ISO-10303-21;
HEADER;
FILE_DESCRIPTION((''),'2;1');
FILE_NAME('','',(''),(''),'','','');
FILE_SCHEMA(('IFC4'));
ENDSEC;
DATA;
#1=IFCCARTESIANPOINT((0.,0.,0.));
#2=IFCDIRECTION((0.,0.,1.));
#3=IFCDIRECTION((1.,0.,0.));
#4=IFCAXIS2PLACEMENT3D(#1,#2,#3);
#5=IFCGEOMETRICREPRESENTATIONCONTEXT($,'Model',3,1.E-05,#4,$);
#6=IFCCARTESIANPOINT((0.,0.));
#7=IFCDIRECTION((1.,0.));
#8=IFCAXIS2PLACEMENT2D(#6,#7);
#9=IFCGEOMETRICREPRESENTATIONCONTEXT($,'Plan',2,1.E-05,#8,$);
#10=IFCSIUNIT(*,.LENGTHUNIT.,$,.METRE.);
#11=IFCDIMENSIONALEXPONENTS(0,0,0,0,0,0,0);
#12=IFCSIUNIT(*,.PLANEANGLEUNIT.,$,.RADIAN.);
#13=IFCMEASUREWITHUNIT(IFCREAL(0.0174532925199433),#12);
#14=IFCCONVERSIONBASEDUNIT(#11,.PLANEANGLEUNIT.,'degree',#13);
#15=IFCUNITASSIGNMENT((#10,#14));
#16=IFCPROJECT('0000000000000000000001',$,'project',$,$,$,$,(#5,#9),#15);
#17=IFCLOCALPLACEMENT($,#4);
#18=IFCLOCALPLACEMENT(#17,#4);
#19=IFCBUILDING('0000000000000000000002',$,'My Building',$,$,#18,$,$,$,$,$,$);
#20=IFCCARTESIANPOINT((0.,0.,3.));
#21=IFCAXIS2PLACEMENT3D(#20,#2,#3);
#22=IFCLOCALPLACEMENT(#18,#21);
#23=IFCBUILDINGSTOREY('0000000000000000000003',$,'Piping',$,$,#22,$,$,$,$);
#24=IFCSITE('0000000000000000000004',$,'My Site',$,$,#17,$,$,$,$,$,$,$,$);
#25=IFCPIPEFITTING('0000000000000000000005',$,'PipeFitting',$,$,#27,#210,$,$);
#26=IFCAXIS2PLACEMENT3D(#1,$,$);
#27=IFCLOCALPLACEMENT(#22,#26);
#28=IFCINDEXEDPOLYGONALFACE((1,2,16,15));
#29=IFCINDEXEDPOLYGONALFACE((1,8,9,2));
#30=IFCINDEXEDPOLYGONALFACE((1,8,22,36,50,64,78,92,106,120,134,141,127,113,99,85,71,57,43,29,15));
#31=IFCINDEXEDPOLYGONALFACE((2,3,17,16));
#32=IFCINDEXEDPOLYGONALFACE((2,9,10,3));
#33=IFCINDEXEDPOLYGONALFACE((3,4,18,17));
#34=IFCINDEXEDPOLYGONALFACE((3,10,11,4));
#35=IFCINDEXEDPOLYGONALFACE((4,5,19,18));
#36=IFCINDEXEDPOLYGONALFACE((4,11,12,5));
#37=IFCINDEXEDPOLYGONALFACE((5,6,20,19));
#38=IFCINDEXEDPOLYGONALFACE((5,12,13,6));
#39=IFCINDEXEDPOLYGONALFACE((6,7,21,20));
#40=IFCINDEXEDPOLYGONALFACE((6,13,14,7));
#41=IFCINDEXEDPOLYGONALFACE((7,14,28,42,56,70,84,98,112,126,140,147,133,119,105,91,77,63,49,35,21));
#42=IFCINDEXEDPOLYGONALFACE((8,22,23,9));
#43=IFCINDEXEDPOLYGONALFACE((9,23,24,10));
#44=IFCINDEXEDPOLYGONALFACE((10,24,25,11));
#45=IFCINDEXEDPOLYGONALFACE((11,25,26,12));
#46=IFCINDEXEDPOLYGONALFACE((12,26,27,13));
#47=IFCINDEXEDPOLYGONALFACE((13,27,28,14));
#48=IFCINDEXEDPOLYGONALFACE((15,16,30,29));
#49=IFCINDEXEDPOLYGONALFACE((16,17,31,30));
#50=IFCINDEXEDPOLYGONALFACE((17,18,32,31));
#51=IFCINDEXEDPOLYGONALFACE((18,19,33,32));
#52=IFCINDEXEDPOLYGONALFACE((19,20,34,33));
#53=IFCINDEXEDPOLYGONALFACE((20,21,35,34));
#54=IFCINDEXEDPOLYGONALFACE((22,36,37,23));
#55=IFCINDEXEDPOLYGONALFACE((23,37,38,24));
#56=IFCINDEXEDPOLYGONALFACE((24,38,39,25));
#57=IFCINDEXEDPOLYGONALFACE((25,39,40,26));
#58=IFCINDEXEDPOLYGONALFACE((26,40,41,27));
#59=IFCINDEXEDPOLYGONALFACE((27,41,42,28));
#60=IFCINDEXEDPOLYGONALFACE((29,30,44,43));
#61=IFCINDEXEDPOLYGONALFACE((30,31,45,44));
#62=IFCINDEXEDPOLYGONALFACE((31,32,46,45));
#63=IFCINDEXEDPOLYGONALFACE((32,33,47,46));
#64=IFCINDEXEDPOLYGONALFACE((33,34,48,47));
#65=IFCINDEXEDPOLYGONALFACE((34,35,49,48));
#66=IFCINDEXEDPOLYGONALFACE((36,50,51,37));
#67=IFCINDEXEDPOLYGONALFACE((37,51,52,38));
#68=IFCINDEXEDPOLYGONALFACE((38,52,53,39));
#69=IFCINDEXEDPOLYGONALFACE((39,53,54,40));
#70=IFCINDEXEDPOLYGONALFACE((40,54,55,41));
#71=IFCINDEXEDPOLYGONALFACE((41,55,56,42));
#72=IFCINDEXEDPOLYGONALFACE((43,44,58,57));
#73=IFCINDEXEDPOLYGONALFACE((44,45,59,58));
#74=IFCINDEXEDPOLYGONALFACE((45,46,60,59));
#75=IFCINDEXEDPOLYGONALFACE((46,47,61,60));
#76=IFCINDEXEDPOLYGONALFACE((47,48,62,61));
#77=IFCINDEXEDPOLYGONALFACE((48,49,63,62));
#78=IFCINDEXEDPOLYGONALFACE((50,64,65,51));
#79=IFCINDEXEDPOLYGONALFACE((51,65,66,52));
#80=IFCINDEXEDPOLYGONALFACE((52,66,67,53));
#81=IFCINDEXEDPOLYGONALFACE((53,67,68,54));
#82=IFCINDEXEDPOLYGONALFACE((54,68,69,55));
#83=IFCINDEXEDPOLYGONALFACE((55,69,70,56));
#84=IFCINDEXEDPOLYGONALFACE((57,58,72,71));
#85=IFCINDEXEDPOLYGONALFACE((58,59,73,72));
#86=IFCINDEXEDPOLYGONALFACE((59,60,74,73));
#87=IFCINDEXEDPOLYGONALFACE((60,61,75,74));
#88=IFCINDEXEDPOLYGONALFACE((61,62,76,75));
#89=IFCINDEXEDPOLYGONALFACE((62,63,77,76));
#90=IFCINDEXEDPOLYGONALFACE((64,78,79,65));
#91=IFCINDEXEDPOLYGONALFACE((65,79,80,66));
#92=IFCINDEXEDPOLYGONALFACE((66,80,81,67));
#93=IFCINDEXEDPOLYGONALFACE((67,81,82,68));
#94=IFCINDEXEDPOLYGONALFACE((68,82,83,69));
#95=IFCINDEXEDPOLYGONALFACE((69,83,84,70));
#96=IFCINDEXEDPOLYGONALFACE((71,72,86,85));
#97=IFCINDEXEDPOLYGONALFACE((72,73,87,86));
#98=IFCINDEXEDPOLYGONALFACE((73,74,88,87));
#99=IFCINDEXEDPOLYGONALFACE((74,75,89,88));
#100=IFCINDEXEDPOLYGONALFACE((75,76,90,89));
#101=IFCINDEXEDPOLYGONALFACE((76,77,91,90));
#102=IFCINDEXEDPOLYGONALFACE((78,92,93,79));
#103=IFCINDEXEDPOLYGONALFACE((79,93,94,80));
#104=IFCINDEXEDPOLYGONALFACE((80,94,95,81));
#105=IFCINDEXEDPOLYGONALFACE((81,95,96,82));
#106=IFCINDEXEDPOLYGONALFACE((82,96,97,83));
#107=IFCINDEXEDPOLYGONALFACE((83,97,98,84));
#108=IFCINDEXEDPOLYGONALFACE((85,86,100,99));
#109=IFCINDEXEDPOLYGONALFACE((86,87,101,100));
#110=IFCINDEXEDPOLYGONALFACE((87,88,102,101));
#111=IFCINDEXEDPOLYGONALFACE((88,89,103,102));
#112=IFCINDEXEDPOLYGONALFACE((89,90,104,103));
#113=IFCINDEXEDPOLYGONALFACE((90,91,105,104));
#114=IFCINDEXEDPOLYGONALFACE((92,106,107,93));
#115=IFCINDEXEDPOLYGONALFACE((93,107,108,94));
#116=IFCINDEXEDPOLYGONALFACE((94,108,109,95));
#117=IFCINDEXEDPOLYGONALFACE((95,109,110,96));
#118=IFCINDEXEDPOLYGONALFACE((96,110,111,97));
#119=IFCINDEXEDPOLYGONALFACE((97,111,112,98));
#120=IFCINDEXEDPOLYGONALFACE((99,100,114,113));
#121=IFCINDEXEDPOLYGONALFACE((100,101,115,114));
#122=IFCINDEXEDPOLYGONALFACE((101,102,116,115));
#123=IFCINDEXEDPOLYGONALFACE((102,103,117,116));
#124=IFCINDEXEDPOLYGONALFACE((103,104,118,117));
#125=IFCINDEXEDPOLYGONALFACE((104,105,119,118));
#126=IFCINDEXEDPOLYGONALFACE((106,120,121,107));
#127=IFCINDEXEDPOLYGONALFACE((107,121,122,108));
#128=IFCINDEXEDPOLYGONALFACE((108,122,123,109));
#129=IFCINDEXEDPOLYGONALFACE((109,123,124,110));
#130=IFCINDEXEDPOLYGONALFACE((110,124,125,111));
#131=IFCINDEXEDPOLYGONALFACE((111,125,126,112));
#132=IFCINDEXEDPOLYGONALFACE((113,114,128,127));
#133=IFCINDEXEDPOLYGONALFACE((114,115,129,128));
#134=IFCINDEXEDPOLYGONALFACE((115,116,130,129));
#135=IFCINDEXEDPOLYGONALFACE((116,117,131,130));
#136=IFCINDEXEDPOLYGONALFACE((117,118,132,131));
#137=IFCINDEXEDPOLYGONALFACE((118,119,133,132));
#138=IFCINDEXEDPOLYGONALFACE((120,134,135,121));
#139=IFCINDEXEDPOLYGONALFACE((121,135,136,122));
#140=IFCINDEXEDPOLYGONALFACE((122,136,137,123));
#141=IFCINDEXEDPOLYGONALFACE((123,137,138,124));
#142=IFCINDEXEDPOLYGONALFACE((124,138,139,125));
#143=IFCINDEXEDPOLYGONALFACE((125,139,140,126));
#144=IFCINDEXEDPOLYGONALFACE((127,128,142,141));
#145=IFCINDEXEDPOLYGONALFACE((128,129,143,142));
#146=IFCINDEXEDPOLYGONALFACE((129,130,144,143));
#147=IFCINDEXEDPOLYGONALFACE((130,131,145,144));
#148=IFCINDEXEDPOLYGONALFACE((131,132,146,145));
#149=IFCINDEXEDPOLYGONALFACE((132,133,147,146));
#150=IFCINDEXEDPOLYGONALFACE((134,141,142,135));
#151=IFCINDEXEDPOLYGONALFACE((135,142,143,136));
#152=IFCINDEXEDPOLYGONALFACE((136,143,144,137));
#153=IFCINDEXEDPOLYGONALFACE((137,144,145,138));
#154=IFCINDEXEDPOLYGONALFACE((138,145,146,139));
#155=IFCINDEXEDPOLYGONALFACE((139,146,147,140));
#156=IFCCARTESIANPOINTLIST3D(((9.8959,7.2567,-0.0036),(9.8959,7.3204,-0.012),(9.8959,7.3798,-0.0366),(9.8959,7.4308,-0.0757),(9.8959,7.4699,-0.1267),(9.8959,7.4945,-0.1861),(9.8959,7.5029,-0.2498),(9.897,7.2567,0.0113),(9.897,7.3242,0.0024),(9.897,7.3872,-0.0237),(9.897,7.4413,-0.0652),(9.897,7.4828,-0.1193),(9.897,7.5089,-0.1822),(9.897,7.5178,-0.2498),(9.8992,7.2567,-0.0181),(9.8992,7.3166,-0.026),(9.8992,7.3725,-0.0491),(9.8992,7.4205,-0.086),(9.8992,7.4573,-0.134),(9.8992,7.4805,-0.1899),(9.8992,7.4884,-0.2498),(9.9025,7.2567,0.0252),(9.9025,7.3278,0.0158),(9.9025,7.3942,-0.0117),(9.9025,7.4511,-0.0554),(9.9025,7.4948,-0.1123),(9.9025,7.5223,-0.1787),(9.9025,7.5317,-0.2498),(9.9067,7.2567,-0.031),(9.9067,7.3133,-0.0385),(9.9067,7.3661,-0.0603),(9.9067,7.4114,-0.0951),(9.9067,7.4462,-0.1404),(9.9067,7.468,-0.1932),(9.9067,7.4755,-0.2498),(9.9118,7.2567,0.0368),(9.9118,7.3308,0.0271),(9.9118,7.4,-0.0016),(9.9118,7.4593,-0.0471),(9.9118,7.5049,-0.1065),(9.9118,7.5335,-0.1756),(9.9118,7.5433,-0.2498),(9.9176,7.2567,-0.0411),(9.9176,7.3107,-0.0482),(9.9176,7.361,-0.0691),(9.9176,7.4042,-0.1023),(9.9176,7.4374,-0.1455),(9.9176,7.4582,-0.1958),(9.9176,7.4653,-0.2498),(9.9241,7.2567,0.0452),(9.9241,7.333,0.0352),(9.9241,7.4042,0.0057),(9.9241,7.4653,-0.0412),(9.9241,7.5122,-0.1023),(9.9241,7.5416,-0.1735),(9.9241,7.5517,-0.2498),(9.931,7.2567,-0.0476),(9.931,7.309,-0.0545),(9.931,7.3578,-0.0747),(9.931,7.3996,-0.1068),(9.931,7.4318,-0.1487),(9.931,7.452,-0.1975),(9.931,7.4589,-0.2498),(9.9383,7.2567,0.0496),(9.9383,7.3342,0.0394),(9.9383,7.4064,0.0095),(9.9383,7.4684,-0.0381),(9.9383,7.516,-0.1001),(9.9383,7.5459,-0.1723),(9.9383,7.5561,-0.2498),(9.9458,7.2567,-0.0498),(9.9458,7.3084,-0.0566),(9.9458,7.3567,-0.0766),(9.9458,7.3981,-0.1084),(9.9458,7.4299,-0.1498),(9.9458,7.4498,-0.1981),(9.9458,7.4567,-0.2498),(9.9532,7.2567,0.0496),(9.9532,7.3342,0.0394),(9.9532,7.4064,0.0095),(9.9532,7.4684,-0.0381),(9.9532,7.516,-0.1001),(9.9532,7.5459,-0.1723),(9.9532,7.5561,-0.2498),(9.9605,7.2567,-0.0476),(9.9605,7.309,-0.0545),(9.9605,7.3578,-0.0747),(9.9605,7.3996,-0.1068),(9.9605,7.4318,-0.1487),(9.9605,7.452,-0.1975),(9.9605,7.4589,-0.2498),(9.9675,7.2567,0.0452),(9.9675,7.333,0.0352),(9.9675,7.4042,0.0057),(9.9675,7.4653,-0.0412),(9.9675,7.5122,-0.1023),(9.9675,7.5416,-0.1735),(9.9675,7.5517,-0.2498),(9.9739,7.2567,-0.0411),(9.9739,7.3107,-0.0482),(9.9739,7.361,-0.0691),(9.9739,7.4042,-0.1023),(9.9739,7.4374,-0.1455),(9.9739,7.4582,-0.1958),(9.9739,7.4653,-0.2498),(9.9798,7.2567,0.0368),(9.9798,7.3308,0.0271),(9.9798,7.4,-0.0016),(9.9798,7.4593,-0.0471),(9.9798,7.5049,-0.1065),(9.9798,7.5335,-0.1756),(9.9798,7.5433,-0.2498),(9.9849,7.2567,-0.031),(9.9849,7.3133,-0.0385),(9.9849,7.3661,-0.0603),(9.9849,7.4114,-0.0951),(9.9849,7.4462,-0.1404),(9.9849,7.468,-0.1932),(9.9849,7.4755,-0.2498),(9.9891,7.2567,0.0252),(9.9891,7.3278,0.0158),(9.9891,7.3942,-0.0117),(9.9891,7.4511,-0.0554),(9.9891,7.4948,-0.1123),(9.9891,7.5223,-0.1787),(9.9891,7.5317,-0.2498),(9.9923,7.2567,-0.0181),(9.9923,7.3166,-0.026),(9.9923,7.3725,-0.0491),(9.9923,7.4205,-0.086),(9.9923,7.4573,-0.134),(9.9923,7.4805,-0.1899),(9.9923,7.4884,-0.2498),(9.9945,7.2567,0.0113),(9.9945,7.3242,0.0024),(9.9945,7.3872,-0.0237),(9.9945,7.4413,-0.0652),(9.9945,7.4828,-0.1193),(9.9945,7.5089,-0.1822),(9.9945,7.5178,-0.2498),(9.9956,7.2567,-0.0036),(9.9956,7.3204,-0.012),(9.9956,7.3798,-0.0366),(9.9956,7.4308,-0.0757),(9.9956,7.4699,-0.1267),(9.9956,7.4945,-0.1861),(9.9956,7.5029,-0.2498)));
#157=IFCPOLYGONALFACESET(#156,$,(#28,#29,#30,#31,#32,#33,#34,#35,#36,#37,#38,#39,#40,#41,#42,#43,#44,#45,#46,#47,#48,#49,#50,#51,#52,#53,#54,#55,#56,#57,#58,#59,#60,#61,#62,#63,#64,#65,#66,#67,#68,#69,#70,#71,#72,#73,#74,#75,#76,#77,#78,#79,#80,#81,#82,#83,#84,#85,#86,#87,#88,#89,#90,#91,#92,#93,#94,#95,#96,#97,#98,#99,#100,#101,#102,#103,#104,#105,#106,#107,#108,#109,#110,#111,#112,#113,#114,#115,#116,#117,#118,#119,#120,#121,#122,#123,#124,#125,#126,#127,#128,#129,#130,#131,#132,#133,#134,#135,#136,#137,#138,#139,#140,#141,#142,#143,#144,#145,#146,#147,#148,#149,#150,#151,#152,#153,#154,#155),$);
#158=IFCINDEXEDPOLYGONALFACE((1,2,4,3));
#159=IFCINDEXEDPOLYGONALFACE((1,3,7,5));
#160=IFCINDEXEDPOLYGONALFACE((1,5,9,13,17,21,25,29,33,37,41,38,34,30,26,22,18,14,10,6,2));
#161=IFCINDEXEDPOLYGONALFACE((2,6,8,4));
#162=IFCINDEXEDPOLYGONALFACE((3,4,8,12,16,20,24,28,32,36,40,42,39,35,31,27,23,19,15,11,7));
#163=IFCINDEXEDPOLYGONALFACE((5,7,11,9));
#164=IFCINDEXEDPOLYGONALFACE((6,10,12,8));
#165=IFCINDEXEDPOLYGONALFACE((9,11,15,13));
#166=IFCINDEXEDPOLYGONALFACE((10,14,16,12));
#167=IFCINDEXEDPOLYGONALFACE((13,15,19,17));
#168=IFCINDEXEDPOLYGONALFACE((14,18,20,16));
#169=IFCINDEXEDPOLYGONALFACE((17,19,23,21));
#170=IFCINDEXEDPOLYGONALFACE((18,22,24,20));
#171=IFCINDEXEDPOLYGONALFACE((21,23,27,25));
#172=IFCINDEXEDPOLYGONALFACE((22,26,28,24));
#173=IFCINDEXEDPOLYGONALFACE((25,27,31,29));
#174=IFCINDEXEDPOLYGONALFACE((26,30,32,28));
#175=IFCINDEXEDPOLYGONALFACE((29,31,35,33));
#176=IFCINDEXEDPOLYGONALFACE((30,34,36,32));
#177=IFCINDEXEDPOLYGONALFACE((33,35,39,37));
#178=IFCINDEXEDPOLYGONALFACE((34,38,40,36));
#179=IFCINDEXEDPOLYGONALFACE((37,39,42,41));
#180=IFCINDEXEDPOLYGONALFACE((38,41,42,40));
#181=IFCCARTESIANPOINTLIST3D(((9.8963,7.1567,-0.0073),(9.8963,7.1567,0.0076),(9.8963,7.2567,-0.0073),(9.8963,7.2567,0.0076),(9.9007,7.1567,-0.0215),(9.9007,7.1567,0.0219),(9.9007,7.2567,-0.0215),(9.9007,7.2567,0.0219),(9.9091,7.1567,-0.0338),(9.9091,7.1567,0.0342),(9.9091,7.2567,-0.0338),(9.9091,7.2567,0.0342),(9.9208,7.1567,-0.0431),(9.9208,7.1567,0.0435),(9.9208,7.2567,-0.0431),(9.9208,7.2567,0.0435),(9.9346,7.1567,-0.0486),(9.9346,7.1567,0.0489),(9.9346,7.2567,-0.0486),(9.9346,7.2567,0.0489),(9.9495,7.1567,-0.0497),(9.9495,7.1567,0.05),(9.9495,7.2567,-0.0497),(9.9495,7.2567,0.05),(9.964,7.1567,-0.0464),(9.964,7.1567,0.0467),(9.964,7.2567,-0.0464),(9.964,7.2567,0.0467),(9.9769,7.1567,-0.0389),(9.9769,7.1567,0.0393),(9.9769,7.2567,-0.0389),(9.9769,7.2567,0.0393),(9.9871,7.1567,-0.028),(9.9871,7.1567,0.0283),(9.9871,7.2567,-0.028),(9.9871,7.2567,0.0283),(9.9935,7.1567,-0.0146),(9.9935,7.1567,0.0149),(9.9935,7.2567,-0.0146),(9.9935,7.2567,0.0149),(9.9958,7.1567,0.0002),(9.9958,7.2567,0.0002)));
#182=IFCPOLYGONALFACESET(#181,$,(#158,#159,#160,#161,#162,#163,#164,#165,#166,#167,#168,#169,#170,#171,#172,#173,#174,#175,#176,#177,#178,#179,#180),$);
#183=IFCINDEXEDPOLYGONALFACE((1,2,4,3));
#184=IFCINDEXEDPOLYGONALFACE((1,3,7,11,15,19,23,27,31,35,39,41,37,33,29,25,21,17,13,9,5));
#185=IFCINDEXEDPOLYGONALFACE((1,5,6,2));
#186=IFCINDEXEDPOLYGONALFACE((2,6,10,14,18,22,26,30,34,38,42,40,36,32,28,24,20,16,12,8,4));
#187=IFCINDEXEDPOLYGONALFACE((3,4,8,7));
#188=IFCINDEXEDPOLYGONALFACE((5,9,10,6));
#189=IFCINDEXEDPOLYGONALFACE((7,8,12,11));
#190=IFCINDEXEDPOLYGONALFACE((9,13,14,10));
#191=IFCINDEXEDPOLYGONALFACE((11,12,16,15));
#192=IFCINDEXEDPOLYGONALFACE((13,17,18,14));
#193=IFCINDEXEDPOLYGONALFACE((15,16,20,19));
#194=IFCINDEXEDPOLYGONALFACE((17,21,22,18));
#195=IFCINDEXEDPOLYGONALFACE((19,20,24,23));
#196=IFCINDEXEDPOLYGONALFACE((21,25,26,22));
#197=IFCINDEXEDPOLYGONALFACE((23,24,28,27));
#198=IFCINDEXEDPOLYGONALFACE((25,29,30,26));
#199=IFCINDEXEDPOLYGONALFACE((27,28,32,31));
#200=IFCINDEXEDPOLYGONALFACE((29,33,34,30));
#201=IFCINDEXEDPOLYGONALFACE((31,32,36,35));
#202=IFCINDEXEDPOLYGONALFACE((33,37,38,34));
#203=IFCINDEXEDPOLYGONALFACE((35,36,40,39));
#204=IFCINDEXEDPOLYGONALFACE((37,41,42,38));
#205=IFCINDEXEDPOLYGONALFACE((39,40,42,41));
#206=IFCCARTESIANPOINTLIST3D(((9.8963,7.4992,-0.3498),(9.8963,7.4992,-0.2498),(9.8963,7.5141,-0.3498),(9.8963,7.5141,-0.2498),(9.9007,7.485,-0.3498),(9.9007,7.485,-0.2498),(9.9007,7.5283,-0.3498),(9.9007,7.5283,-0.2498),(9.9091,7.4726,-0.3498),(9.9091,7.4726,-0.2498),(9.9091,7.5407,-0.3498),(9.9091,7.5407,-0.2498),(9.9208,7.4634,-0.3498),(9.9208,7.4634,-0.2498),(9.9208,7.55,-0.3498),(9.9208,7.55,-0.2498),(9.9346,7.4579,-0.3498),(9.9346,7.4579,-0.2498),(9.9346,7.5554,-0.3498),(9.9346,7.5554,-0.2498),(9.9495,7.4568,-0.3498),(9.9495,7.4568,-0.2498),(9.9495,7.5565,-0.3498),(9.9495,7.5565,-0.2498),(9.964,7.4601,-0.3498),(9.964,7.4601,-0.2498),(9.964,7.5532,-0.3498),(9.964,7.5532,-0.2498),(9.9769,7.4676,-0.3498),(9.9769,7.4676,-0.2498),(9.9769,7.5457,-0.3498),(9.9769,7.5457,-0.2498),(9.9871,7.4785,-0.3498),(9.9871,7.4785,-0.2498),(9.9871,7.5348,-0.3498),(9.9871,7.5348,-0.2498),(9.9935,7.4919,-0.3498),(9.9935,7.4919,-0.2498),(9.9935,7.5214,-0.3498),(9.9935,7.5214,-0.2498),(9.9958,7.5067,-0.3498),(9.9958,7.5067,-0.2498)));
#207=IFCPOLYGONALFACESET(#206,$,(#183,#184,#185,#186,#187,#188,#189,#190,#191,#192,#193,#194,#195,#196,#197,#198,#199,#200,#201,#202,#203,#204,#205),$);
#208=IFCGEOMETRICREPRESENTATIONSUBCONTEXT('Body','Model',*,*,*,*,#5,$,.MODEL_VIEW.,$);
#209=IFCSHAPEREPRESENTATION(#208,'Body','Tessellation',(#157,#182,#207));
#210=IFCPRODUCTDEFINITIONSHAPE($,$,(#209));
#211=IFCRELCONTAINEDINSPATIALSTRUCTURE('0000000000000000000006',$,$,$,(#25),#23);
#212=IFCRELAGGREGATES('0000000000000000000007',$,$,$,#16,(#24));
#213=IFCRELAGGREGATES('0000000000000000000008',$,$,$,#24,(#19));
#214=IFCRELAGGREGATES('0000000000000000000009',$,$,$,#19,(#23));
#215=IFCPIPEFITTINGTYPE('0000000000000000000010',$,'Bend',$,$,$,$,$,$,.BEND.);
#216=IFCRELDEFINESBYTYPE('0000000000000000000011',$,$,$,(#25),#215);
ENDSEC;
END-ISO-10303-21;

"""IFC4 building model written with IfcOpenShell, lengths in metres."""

from ifc_helpers import new_model, entity, si_unit, converted_unit, frame, origin_with_axes, origin_2d_with_axis, place, context, subcontext, project, spatial, circle, extrude, source, transform, mapped, type_object, type_shapes, element, save


model = new_model("IFC4")

# Units and contexts
model_context = context("Model", 3, precision=1e-05, world=origin_with_axes())
plan_context = context("Plan", 2, precision=1e-05, world=origin_2d_with_axis())
body_context = subcontext(model_context, "Body", "Model", "MODEL_VIEW")
ifc_project = project(units=[si_unit("LENGTHUNIT", "METRE"), converted_unit("PLANEANGLEUNIT", "degree", entity("IfcReal", 0.0174532925199433), si_unit("PLANEANGLEUNIT", "RADIAN"), dimensions=[0, 0, 0, 0, 0, 0, 0])], contexts=[model_context, plan_context])

# Site, building, storey
site_placement = place(None, origin_with_axes())
site = spatial("IfcSite", under=ifc_project, at=site_placement, Name="My Site")
building_placement = place(site_placement, origin_with_axes())
building = spatial("IfcBuilding", under=site, at=building_placement, Name="My Building")
storey_placement = place(building_placement, frame((0.0, 0.0, 3.0), z_axis=(0.0, 0.0, 1.0), x_axis=(1.0, 0.0, 0.0)))
storey = spatial("IfcBuildingStorey", under=building, at=storey_placement, Name="Piping")

# Pipe fitting
pipe_fitting_type = type_object("IfcPipeFittingType", Name="Bend", PredefinedType="BEND")
shared_shape = source(origin_with_axes(), body_context, "Body", "SolidModel", [
    entity("IfcSweptDiskSolid", entity("IfcIndexedPolyCurve", entity("IfcCartesianPointList3D", [[0.0, 0.0, -0.1], [0.0, -0.0732, -0.2768], [0.0, -0.25, -0.35]]), [entity("IfcArcIndex", [1, 2, 3])]), 0.05),
    extrude(circle(Radius=0.05), origin_with_axes(), (0.0, 0.0, -1.0), 0.1),
    extrude(circle(Radius=0.05), frame((0.0, -0.25, -0.35), z_axis=(0.0, -1.0, 0.0), x_axis=(1.0, 0.0, 0.0)), (0.0, 0.0, 1.0), 0.1),
])
type_shapes(pipe_fitting_type, [shared_shape])
for number, where, z_axis, x_axis, name in (
    (1, (9.9458, 7.1567, 0.0002), (0.0, -1.0, 0.0), (1.0, 0.0, 0.0), "PipeFitting"),
):
    element("IfcPipeFitting", number, at=place(storey_placement, frame(where, z_axis=z_axis, x_axis=x_axis)), inside=storey, type_object=pipe_fitting_type, Name=name, context=body_context, shape_type="MappedRepresentation", body=[
        mapped(shared_shape, transform((0.0, 0.0, 0.0), x_axis=(1.0, 0.0, 0.0), y_axis=(0.0, 1.0, 0.0), z_axis=(0.0, 0.0, 1.0), scale=1.0)),
    ])

save(model, "model.ifc")
